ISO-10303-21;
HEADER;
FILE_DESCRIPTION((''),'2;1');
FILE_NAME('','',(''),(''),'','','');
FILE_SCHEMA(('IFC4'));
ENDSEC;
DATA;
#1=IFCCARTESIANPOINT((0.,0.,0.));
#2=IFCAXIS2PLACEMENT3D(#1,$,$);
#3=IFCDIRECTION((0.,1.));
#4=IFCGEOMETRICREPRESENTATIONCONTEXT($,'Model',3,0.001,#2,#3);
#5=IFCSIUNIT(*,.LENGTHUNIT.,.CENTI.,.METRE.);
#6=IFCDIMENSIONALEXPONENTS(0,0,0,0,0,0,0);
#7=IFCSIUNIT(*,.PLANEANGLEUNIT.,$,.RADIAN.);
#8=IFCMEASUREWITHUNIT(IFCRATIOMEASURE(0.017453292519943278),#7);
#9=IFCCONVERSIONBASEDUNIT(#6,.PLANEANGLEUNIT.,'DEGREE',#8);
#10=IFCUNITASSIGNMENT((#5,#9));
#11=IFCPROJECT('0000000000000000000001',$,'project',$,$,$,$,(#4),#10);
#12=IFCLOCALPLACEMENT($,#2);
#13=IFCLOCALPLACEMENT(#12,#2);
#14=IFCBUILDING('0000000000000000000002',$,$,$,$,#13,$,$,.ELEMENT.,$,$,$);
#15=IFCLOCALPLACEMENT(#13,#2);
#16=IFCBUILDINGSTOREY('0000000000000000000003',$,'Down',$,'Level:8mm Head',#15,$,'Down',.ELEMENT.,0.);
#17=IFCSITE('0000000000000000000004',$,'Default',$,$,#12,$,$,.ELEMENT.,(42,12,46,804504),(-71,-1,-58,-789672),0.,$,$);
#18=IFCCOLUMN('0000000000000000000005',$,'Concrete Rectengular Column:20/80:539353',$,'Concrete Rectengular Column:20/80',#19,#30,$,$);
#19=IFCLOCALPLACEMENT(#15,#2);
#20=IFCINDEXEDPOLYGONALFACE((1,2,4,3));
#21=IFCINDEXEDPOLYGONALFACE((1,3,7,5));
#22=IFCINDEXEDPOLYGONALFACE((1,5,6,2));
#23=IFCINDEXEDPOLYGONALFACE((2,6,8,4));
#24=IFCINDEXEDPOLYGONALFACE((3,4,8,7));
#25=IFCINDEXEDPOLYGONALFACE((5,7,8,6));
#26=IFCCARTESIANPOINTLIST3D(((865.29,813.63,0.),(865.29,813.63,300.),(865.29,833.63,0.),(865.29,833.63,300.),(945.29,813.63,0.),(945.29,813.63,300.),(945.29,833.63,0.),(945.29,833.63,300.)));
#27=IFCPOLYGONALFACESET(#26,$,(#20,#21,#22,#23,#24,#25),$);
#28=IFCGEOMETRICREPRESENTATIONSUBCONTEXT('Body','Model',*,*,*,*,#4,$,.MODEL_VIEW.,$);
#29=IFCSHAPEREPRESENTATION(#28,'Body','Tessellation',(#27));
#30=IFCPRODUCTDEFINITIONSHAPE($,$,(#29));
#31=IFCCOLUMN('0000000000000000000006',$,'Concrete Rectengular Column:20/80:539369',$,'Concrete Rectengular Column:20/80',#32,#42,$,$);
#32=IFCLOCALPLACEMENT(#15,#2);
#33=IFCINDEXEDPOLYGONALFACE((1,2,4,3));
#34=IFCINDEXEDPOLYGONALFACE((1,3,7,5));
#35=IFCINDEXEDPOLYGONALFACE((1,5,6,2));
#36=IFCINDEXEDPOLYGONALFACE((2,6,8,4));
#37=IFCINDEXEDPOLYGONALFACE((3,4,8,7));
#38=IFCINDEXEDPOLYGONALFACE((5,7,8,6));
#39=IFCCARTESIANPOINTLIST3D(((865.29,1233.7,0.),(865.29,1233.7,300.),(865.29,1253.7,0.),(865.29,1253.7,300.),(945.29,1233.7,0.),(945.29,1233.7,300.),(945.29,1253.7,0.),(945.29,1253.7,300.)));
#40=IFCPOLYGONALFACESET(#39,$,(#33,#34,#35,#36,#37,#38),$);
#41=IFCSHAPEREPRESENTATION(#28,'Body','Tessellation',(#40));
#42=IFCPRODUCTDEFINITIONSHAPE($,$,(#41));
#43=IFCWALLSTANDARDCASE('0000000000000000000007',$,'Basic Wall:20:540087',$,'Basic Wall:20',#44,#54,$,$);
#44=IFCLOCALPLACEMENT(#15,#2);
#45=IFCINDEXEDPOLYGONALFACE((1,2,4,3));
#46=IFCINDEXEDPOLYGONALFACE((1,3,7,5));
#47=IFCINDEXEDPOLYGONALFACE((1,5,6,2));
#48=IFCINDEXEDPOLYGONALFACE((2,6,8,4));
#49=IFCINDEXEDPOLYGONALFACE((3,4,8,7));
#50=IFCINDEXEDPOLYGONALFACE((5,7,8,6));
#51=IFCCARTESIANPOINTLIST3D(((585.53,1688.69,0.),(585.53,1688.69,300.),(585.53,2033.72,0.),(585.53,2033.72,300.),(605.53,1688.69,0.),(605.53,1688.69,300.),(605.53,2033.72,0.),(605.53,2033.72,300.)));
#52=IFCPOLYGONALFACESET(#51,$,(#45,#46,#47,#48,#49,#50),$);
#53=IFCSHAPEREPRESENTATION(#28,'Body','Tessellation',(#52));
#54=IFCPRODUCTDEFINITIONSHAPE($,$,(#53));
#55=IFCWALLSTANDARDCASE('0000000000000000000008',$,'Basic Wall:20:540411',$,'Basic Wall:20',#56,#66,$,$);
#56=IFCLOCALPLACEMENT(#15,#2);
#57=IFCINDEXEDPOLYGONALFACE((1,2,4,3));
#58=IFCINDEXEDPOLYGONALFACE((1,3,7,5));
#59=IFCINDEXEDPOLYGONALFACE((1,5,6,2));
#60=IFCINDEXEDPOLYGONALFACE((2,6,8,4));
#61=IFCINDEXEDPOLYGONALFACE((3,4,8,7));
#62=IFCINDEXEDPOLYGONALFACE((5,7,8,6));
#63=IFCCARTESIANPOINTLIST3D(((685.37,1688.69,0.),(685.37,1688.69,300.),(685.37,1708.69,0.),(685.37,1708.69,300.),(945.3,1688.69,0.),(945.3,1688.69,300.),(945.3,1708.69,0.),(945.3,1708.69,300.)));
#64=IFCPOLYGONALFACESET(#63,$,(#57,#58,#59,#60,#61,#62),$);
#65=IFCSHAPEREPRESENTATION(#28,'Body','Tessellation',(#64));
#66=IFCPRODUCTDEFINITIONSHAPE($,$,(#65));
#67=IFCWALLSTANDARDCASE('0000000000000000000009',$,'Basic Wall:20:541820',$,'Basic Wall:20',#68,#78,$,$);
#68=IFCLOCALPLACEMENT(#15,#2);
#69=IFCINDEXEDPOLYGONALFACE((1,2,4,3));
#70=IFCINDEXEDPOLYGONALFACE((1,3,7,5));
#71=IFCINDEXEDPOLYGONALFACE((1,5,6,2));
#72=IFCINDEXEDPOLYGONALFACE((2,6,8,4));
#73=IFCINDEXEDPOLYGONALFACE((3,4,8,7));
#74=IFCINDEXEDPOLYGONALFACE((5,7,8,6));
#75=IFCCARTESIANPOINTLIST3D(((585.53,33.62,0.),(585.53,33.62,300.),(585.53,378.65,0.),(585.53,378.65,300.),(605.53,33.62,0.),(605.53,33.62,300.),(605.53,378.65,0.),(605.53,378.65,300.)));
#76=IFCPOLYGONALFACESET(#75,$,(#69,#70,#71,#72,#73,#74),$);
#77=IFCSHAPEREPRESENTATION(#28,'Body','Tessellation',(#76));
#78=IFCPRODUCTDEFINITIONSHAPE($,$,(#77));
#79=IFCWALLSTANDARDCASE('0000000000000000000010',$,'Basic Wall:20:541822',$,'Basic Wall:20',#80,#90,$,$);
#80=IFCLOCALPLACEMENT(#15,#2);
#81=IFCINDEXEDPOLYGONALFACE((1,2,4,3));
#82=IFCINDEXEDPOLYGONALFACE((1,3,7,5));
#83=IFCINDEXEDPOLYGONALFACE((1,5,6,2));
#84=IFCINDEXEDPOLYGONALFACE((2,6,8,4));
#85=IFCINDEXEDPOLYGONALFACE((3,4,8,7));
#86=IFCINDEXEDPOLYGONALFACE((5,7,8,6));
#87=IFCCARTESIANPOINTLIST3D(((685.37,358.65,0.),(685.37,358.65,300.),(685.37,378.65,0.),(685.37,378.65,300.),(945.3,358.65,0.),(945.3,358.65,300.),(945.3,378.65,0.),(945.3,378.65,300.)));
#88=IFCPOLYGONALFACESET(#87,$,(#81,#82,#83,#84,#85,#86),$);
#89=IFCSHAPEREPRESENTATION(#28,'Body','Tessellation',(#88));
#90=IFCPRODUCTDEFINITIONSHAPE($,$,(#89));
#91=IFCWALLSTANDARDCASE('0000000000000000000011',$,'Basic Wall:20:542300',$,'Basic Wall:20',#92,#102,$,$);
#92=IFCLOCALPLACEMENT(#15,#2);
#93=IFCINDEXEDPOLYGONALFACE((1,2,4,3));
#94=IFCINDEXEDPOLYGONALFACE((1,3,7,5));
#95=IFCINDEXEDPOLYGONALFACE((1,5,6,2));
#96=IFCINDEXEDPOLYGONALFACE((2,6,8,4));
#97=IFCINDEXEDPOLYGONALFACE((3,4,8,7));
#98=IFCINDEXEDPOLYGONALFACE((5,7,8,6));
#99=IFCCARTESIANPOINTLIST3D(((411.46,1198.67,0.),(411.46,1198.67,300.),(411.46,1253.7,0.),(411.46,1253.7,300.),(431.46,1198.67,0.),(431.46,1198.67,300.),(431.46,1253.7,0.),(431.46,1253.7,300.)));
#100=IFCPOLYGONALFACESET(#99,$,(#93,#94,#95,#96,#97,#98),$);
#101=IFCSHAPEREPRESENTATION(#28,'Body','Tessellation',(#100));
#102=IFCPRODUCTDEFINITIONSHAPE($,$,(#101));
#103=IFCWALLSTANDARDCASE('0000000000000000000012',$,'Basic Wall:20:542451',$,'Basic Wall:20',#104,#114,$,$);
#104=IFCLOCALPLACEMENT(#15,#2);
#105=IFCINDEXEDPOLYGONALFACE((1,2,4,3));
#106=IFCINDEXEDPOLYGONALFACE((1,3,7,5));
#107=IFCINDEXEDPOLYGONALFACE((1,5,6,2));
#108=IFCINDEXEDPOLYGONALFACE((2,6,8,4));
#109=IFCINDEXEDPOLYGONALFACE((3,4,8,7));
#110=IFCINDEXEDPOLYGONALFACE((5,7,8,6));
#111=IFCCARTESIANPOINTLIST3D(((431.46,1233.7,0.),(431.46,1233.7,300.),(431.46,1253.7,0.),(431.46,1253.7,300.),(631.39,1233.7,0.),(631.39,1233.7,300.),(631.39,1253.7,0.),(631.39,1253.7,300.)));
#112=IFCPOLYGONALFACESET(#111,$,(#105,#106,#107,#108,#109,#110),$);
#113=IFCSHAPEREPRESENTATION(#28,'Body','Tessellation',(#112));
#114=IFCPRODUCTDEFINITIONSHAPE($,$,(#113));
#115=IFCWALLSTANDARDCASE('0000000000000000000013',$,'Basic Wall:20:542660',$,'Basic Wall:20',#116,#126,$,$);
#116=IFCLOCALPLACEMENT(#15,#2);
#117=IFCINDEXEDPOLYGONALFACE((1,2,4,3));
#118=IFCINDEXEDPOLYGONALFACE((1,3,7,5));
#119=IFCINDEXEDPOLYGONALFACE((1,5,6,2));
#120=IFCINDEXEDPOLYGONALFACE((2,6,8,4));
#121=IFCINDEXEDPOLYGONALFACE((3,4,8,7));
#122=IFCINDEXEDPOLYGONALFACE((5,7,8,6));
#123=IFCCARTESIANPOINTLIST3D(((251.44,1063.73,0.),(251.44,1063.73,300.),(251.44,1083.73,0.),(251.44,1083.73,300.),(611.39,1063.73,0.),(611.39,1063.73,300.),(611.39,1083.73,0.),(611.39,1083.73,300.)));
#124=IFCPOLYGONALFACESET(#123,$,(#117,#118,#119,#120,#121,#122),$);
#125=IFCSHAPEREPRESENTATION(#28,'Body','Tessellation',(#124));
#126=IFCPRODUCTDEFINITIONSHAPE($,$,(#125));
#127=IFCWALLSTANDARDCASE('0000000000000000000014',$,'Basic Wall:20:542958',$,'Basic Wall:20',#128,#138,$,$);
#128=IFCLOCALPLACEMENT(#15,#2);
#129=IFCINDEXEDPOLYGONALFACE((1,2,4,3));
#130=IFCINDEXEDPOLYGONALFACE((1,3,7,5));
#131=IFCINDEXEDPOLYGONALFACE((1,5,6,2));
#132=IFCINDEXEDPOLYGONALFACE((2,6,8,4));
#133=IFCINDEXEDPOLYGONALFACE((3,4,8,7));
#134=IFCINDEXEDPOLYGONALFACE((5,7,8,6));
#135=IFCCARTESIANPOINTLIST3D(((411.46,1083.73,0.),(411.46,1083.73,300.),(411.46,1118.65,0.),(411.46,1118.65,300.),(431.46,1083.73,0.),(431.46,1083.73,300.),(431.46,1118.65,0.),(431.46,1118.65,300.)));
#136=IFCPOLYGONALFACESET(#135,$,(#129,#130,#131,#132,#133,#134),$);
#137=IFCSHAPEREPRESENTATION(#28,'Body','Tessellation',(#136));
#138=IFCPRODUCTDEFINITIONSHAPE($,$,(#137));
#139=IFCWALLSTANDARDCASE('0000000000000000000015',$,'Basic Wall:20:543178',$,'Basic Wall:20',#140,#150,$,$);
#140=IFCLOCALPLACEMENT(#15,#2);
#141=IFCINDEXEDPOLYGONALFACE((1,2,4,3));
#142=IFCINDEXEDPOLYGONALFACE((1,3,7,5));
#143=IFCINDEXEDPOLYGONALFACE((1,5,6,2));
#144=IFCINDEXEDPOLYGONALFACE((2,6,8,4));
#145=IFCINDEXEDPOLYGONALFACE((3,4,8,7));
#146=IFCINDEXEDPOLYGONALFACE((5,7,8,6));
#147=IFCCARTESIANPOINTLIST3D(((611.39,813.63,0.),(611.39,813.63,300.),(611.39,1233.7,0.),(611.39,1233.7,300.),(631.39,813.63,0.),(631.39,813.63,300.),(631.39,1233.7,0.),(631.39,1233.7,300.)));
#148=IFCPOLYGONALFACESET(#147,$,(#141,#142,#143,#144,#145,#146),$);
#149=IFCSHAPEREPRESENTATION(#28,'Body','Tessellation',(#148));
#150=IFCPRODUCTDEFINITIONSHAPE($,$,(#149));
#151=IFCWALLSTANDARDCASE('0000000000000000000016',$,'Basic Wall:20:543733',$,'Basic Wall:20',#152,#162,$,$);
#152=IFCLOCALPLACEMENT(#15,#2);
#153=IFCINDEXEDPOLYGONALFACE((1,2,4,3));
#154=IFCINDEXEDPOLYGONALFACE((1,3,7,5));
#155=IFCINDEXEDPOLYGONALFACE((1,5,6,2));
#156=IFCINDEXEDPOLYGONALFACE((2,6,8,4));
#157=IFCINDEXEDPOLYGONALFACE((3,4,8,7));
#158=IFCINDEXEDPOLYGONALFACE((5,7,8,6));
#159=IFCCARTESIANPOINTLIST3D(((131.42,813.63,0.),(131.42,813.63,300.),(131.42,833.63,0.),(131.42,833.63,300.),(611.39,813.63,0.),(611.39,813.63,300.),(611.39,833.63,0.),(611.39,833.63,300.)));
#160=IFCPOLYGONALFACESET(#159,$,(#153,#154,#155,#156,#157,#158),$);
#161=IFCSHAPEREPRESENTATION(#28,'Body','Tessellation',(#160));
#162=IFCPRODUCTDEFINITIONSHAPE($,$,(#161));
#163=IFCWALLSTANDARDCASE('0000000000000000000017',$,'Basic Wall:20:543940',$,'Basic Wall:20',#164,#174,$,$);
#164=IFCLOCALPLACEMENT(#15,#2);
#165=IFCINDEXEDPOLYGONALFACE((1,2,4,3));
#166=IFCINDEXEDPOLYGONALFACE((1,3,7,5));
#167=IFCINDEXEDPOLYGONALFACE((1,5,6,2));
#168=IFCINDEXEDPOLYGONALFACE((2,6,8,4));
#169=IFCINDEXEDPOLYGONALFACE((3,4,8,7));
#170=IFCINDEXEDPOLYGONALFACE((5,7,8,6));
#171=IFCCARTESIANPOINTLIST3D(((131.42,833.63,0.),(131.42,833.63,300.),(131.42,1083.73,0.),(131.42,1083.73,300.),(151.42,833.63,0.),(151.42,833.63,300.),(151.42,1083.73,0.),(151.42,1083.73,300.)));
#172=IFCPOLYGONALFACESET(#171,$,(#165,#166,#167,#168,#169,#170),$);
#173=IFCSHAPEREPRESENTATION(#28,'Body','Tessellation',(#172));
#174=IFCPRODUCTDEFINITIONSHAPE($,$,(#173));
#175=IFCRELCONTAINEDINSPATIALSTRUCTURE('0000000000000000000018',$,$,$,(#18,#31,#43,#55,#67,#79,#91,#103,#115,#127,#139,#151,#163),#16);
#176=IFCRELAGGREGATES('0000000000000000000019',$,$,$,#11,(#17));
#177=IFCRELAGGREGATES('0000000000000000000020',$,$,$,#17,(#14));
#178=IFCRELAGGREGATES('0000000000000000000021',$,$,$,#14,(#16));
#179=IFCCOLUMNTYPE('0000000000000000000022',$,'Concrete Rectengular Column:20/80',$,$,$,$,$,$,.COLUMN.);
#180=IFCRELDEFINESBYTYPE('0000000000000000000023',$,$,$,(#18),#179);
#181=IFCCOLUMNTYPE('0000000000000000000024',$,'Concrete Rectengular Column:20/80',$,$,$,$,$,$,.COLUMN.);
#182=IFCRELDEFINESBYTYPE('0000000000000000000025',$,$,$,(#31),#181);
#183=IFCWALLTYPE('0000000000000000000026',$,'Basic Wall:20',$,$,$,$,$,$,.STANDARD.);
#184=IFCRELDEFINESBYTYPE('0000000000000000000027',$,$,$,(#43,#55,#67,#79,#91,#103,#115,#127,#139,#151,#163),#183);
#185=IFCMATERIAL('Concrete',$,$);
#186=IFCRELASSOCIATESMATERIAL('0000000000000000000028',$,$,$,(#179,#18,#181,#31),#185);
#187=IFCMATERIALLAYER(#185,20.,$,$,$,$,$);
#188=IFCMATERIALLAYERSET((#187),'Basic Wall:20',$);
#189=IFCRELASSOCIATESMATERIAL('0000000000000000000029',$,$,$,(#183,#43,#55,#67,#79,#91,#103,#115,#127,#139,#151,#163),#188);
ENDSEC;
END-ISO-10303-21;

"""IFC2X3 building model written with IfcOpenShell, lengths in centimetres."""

from ifc_helpers import new_model, entity, si_unit, converted_unit, direction, frame, frame_2d, origin, origin_2d_with_axis, place, context, subcontext, project, spatial, rectangle, extrude, source, transform, mapped, material, layer, layer_set, layer_usage, type_object, type_shapes, element, save


model = new_model("IFC2X3")

# Units and contexts
model_context = context("Model", 3, precision=0.001, world=origin(), true_north=direction((0.0, 1.0)))
body_context = subcontext(model_context, "Body", "Model", "MODEL_VIEW")
ifc_project = project(units=[si_unit("LENGTHUNIT", "METRE", prefix="CENTI"), converted_unit("PLANEANGLEUNIT", "DEGREE", entity("IfcRatioMeasure", 0.017453292519943278), si_unit("PLANEANGLEUNIT", "RADIAN"), dimensions=[0, 0, 0, 0, 0, 0, 0])], contexts=[model_context])

# Site, building, storey
site_placement = place(None, origin())
site = spatial("IfcSite", under=ifc_project, at=site_placement, Name="Default", CompositionType="ELEMENT", RefLatitude=(42, 12, 46, 804504), RefLongitude=(-71, -1, -58, -789672), RefElevation=0.0)
building_placement = place(site_placement, origin())
building = spatial("IfcBuilding", under=site, at=building_placement, CompositionType="ELEMENT")
storey_placement = place(building_placement, origin())
storey = spatial("IfcBuildingStorey", under=building, at=storey_placement, Name="Down", ObjectType="Level:8mm Head", LongName="Down", CompositionType="ELEMENT", Elevation=0.0)

# Columns
ifc_material = material(Name="Concrete")
column_type_1 = type_object("IfcColumnType", Name="Concrete Rectengular Column:20/80", PredefinedType="COLUMN", material=ifc_material)
shared_shape_1 = source(origin(), body_context, "Body", "SweptSolid", [
    extrude(rectangle(XDim=20.0, YDim=80.0, at=origin_2d_with_axis()), frame((905.29, 823.63, 0.0), z_axis=(0.0, 0.0, 1.0), x_axis=(0.0, -1.0, 0.0)), (0.0, 0.0, 1.0), 300.0),
])
type_shapes(column_type_1, [shared_shape_1])
column_1_placement = place(storey_placement, origin())
element("IfcColumn", 1, at=column_1_placement, inside=storey, type_object=column_type_1, material=ifc_material, Name="Concrete Rectengular Column:20/80:539353", ObjectType="Concrete Rectengular Column:20/80", context=body_context, shape_type="MappedRepresentation", body=[
    mapped(shared_shape_1, transform((0.0, 0.0, 0.0), scale=1.0)),
])
column_type_2 = type_object("IfcColumnType", Name="Concrete Rectengular Column:20/80", PredefinedType="COLUMN", material=ifc_material)
shared_shape_2 = source(origin(), body_context, "Body", "SweptSolid", [
    extrude(rectangle(XDim=20.0, YDim=80.0, at=frame_2d((0.0, 0.0), x_axis=(1.0, 0.0))), frame((905.29, 1243.7, 0.0), z_axis=(0.0, 0.0, 1.0), x_axis=(0.0, -1.0, 0.0)), (0.0, 0.0, 1.0), 300.0),
])
type_shapes(column_type_2, [shared_shape_2])
column_2_placement = place(storey_placement, origin())
element("IfcColumn", 2, at=column_2_placement, inside=storey, type_object=column_type_2, material=ifc_material, Name="Concrete Rectengular Column:20/80:539369", ObjectType="Concrete Rectengular Column:20/80", context=body_context, shape_type="MappedRepresentation", body=[
    mapped(shared_shape_2, transform((0.0, 0.0, 0.0), scale=1.0)),
])

# Walls
ifc_layer_1 = layer(ifc_material, 20.0)
ifc_layer_set_1 = layer_set([ifc_layer_1], Name="Basic Wall:20")
ifc_layer_usage_1 = layer_usage(ifc_layer_set_1, "AXIS2", "NEGATIVE", 10.0)
wall_type_1 = type_object("IfcWallType", Name="Basic Wall:20", PredefinedType="STANDARD", material=ifc_layer_set_1)
wall_1_placement = place(storey_placement, frame((595.53, 1688.69, 0.0), z_axis=(0.0, 0.0, 1.0), x_axis=(0.0, 1.0, 0.0)))
element("IfcWallStandardCase", 3, at=wall_1_placement, inside=storey, type_object=wall_type_1, material=ifc_layer_usage_1, Name="Basic Wall:20:540087", ObjectType="Basic Wall:20", context=body_context, shape_type="SweptSolid", body=[
    extrude(rectangle(XDim=345.03, YDim=20.0, at=frame_2d((172.51, 0.0), x_axis=(-1.0, 0.0))), origin(), (0.0, 0.0, 1.0), 300.0),
])
ifc_layer_usage_2 = layer_usage(ifc_layer_set_1, "AXIS2", "POSITIVE", -10.0)
wall_2_placement = place(storey_placement, frame((685.37, 1698.69, 0.0)))
element("IfcWallStandardCase", 4, at=wall_2_placement, inside=storey, type_object=wall_type_1, material=ifc_layer_usage_2, Name="Basic Wall:20:540411", ObjectType="Basic Wall:20", context=body_context, shape_type="SweptSolid", body=[
    extrude(rectangle(XDim=259.93, YDim=20.0, at=frame_2d((129.97, 0.0), x_axis=(-1.0, 0.0))), origin(), (0.0, 0.0, 1.0), 300.0),
])
ifc_layer_usage_3 = layer_usage(ifc_layer_set_1, "AXIS2", "POSITIVE", -10.0)
wall_3_placement = place(storey_placement, frame((595.53, 378.65, 0.0), z_axis=(0.0, 0.0, 1.0), x_axis=(0.0, -1.0, 0.0)))
element("IfcWallStandardCase", 5, at=wall_3_placement, inside=storey, type_object=wall_type_1, material=ifc_layer_usage_3, Name="Basic Wall:20:541820", ObjectType="Basic Wall:20", context=body_context, shape_type="SweptSolid", body=[
    extrude(rectangle(XDim=345.03, YDim=20.0, at=frame_2d((172.51, 0.0), x_axis=(-1.0, 0.0))), origin(), (0.0, 0.0, 1.0), 300.0),
])
ifc_layer_usage_4 = layer_usage(ifc_layer_set_1, "AXIS2", "NEGATIVE", 10.0)
wall_4_placement = place(storey_placement, frame((685.37, 368.65, 0.0)))
element("IfcWallStandardCase", 6, at=wall_4_placement, inside=storey, type_object=wall_type_1, material=ifc_layer_usage_4, Name="Basic Wall:20:541822", ObjectType="Basic Wall:20", context=body_context, shape_type="SweptSolid", body=[
    extrude(rectangle(XDim=259.93, YDim=20.0, at=frame_2d((129.97, 0.0), x_axis=(-1.0, 0.0))), origin(), (0.0, 0.0, 1.0), 300.0),
])
ifc_layer_usage_5 = layer_usage(ifc_layer_set_1, "AXIS2", "NEGATIVE", 10.0)
wall_5_placement = place(storey_placement, frame((421.46, 1198.67, 0.0), z_axis=(0.0, 0.0, 1.0), x_axis=(0.0, 1.0, 0.0)))
element("IfcWallStandardCase", 7, at=wall_5_placement, inside=storey, type_object=wall_type_1, material=ifc_layer_usage_5, Name="Basic Wall:20:542300", ObjectType="Basic Wall:20", context=body_context, shape_type="SweptSolid", body=[
    extrude(rectangle(XDim=55.03, YDim=20.0, at=frame_2d((27.52, 0.0), x_axis=(-1.0, 0.0))), origin(), (0.0, 0.0, 1.0), 300.0),
])
ifc_layer_usage_6 = layer_usage(ifc_layer_set_1, "AXIS2", "NEGATIVE", 10.0)
wall_6_placement = place(storey_placement, frame((431.46, 1243.7, 0.0)))
element("IfcWallStandardCase", 8, at=wall_6_placement, inside=storey, type_object=wall_type_1, material=ifc_layer_usage_6, Name="Basic Wall:20:542451", ObjectType="Basic Wall:20", context=body_context, shape_type="SweptSolid", body=[
    extrude(rectangle(XDim=199.93, YDim=20.0, at=frame_2d((99.96, 0.0), x_axis=(-1.0, 0.0))), origin(), (0.0, 0.0, 1.0), 300.0),
])
ifc_layer_usage_7 = layer_usage(ifc_layer_set_1, "AXIS2", "NEGATIVE", 10.0)
wall_7_placement = place(storey_placement, frame((251.44, 1073.73, 0.0)))
element("IfcWallStandardCase", 9, at=wall_7_placement, inside=storey, type_object=wall_type_1, material=ifc_layer_usage_7, Name="Basic Wall:20:542660", ObjectType="Basic Wall:20", context=body_context, shape_type="SweptSolid", body=[
    extrude(rectangle(XDim=359.95, YDim=20.0, at=frame_2d((179.98, 0.0), x_axis=(-1.0, 0.0))), origin(), (0.0, 0.0, 1.0), 300.0),
])
ifc_layer_usage_8 = layer_usage(ifc_layer_set_1, "AXIS2", "POSITIVE", -10.0)
wall_8_placement = place(storey_placement, frame((421.46, 1118.65, 0.0), z_axis=(0.0, 0.0, 1.0), x_axis=(0.0, -1.0, 0.0)))
element("IfcWallStandardCase", 10, at=wall_8_placement, inside=storey, type_object=wall_type_1, material=ifc_layer_usage_8, Name="Basic Wall:20:542958", ObjectType="Basic Wall:20", context=body_context, shape_type="SweptSolid", body=[
    extrude(rectangle(XDim=34.93, YDim=20.0, at=frame_2d((17.46, 0.0), x_axis=(-1.0, 0.0))), origin(), (0.0, 0.0, 1.0), 300.0),
])
ifc_layer_usage_9 = layer_usage(ifc_layer_set_1, "AXIS2", "NEGATIVE", 10.0)
wall_9_placement = place(storey_placement, frame((621.39, 1233.7, 0.0), z_axis=(0.0, 0.0, 1.0), x_axis=(0.0, -1.0, 0.0)))
element("IfcWallStandardCase", 11, at=wall_9_placement, inside=storey, type_object=wall_type_1, material=ifc_layer_usage_9, Name="Basic Wall:20:543178", ObjectType="Basic Wall:20", context=body_context, shape_type="SweptSolid", body=[
    extrude(rectangle(XDim=420.07, YDim=20.0, at=frame_2d((210.03, 0.0), x_axis=(-1.0, 0.0))), origin(), (0.0, 0.0, 1.0), 300.0),
])
ifc_layer_usage_10 = layer_usage(ifc_layer_set_1, "AXIS2", "NEGATIVE", 10.0)
wall_10_placement = place(storey_placement, frame((611.39, 823.63, 0.0), z_axis=(0.0, 0.0, 1.0), x_axis=(-1.0, 0.0, 0.0)))
element("IfcWallStandardCase", 12, at=wall_10_placement, inside=storey, type_object=wall_type_1, material=ifc_layer_usage_10, Name="Basic Wall:20:543733", ObjectType="Basic Wall:20", context=body_context, shape_type="SweptSolid", body=[
    extrude(rectangle(XDim=479.97, YDim=20.0, at=frame_2d((239.99, 0.0), x_axis=(-1.0, 0.0))), origin(), (0.0, 0.0, 1.0), 300.0),
])
ifc_layer_usage_11 = layer_usage(ifc_layer_set_1, "AXIS2", "NEGATIVE", 10.0)
wall_11_placement = place(storey_placement, frame((141.42, 833.63, 0.0), z_axis=(0.0, 0.0, 1.0), x_axis=(0.0, 1.0, 0.0)))
element("IfcWallStandardCase", 13, at=wall_11_placement, inside=storey, type_object=wall_type_1, material=ifc_layer_usage_11, Name="Basic Wall:20:543940", ObjectType="Basic Wall:20", context=body_context, shape_type="SweptSolid", body=[
    extrude(rectangle(XDim=250.09, YDim=20.0, at=frame_2d((125.05, 0.0), x_axis=(-1.0, 0.0))), origin(), (0.0, 0.0, 1.0), 300.0),
])

save(model, "model.ifc")
